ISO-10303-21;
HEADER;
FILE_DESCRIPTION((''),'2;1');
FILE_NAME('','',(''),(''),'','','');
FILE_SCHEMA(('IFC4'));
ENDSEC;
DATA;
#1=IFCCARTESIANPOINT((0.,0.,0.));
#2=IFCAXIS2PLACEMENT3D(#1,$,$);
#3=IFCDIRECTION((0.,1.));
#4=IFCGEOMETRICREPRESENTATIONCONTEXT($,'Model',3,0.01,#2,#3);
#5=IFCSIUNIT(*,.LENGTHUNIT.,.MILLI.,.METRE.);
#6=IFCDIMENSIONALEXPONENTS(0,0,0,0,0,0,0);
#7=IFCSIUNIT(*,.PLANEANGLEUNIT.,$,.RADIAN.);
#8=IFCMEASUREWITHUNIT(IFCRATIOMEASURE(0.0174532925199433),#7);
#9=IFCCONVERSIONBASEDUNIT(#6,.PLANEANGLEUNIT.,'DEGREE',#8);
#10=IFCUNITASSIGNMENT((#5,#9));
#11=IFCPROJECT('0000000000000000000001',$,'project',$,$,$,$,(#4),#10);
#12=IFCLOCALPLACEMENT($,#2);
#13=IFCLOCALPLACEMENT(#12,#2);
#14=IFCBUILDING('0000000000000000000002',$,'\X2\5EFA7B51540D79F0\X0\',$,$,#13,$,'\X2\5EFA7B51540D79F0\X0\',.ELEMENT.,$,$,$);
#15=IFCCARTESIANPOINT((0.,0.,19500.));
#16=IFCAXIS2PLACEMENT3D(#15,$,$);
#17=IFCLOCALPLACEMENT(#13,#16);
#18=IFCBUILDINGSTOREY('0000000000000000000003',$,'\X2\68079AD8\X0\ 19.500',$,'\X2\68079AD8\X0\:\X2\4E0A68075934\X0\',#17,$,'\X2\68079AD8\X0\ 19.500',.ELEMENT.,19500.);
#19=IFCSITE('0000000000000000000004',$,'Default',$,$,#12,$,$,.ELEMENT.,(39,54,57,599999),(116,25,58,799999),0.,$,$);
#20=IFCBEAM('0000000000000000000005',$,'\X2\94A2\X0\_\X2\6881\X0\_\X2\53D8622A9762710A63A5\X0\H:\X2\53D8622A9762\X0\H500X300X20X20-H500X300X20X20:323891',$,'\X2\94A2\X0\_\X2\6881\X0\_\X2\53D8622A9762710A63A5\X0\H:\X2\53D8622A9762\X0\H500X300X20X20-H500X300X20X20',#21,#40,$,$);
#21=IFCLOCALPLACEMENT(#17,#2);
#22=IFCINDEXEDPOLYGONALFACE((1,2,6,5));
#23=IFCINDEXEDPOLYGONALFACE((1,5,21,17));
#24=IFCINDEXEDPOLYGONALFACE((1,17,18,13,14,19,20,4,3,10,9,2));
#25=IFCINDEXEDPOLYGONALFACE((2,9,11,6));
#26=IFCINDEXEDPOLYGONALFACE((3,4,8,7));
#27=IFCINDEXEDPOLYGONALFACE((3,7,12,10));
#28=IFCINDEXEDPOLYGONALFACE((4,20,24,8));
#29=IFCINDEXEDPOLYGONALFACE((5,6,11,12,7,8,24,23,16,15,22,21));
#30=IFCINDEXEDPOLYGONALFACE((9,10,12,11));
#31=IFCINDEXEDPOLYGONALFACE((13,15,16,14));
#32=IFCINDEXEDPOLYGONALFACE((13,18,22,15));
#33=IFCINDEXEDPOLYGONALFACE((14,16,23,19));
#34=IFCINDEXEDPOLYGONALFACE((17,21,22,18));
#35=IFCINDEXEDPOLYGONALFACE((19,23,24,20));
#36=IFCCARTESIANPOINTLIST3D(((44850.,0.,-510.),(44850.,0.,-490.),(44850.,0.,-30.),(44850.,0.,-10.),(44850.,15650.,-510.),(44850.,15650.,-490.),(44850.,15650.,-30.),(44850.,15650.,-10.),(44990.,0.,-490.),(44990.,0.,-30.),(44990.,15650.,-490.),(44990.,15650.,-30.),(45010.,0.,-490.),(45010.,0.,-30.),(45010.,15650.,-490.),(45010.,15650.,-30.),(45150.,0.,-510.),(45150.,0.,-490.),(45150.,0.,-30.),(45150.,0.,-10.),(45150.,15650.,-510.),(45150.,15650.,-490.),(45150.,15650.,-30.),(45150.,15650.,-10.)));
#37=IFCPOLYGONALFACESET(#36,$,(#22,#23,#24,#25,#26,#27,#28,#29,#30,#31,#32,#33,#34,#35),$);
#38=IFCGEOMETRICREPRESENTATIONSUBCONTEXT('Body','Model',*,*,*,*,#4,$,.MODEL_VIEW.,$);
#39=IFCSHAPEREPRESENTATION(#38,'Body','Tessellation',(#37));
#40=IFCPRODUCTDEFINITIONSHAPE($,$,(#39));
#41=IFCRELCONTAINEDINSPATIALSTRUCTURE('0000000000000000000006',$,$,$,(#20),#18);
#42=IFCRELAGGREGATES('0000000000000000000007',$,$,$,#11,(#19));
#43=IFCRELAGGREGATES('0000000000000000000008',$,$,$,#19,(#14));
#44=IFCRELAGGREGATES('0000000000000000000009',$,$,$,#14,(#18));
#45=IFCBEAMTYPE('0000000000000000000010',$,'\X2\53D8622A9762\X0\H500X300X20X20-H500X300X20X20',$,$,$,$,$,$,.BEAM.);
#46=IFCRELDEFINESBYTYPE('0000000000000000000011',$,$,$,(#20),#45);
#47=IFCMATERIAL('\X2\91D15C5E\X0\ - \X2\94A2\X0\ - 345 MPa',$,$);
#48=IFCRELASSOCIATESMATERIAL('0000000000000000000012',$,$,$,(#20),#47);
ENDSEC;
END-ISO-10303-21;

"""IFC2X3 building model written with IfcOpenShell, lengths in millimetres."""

from ifc_helpers import new_model, entity, si_unit, converted_unit, direction, frame, frame_2d, origin, place, context, subcontext, project, spatial, i_section, extrude, material, type_object, element, save


model = new_model("IFC2X3")

# Units and contexts
model_context = context("Model", 3, precision=0.01, world=origin(), true_north=direction((0.0, 1.0)))
body_context = subcontext(model_context, "Body", "Model", "MODEL_VIEW")
ifc_project = project(units=[si_unit("LENGTHUNIT", "METRE", prefix="MILLI"), converted_unit("PLANEANGLEUNIT", "DEGREE", entity("IfcRatioMeasure", 0.0174532925199433), si_unit("PLANEANGLEUNIT", "RADIAN"), dimensions=[0, 0, 0, 0, 0, 0, 0])], contexts=[model_context])

# Site, building, storey
site_placement = place(None, origin())
site = spatial("IfcSite", under=ifc_project, at=site_placement, Name="Default", CompositionType="ELEMENT", RefLatitude=(39, 54, 57, 599999), RefLongitude=(116, 25, 58, 799999), RefElevation=0.0)
building_placement = place(site_placement, origin())
building = spatial("IfcBuilding", under=site, at=building_placement, Name="建筑名称", LongName="建筑名称", CompositionType="ELEMENT")
storey_placement = place(building_placement, frame((0.0, 0.0, 19500.0)))
storey = spatial("IfcBuildingStorey", under=building, at=storey_placement, Name="标高 19.500", ObjectType="标高:上标头", LongName="标高 19.500", CompositionType="ELEMENT", Elevation=19500.0)

# Beam
ifc_material_1 = material(Name="金属 - 钢 - 345 MPa")
beam_type_1 = type_object("IfcBeamType", Name="变截面H500X300X20X20-H500X300X20X20", PredefinedType="BEAM")
beam_1_placement = place(storey_placement, frame((45000.0, 0.0, 0.0), z_axis=(0.0, 0.0, 1.0), x_axis=(0.0, 1.0, 0.0)))
element("IfcBeam", 1, at=beam_1_placement, inside=storey, type_object=beam_type_1, material=ifc_material_1, Name="钢_梁_变截面焊接H:变截面H500X300X20X20-H500X300X20X20:323891", ObjectType="钢_梁_变截面焊接H:变截面H500X300X20X20-H500X300X20X20", context=body_context, shape_type="SweptSolid", body=[
    extrude(i_section(OverallWidth=300.0, OverallDepth=500.0, WebThickness=20.0, FlangeThickness=20.0, at=frame_2d((0.0, 0.0), x_axis=(0.0, 1.0))), frame((0.0, 0.0, -260.0), z_axis=(1.0, 0.0, 0.0), x_axis=(0.0, 0.0, -1.0)), (0.0, 0.0, 1.0), 15650.0),
])

save(model, "model.ifc")
